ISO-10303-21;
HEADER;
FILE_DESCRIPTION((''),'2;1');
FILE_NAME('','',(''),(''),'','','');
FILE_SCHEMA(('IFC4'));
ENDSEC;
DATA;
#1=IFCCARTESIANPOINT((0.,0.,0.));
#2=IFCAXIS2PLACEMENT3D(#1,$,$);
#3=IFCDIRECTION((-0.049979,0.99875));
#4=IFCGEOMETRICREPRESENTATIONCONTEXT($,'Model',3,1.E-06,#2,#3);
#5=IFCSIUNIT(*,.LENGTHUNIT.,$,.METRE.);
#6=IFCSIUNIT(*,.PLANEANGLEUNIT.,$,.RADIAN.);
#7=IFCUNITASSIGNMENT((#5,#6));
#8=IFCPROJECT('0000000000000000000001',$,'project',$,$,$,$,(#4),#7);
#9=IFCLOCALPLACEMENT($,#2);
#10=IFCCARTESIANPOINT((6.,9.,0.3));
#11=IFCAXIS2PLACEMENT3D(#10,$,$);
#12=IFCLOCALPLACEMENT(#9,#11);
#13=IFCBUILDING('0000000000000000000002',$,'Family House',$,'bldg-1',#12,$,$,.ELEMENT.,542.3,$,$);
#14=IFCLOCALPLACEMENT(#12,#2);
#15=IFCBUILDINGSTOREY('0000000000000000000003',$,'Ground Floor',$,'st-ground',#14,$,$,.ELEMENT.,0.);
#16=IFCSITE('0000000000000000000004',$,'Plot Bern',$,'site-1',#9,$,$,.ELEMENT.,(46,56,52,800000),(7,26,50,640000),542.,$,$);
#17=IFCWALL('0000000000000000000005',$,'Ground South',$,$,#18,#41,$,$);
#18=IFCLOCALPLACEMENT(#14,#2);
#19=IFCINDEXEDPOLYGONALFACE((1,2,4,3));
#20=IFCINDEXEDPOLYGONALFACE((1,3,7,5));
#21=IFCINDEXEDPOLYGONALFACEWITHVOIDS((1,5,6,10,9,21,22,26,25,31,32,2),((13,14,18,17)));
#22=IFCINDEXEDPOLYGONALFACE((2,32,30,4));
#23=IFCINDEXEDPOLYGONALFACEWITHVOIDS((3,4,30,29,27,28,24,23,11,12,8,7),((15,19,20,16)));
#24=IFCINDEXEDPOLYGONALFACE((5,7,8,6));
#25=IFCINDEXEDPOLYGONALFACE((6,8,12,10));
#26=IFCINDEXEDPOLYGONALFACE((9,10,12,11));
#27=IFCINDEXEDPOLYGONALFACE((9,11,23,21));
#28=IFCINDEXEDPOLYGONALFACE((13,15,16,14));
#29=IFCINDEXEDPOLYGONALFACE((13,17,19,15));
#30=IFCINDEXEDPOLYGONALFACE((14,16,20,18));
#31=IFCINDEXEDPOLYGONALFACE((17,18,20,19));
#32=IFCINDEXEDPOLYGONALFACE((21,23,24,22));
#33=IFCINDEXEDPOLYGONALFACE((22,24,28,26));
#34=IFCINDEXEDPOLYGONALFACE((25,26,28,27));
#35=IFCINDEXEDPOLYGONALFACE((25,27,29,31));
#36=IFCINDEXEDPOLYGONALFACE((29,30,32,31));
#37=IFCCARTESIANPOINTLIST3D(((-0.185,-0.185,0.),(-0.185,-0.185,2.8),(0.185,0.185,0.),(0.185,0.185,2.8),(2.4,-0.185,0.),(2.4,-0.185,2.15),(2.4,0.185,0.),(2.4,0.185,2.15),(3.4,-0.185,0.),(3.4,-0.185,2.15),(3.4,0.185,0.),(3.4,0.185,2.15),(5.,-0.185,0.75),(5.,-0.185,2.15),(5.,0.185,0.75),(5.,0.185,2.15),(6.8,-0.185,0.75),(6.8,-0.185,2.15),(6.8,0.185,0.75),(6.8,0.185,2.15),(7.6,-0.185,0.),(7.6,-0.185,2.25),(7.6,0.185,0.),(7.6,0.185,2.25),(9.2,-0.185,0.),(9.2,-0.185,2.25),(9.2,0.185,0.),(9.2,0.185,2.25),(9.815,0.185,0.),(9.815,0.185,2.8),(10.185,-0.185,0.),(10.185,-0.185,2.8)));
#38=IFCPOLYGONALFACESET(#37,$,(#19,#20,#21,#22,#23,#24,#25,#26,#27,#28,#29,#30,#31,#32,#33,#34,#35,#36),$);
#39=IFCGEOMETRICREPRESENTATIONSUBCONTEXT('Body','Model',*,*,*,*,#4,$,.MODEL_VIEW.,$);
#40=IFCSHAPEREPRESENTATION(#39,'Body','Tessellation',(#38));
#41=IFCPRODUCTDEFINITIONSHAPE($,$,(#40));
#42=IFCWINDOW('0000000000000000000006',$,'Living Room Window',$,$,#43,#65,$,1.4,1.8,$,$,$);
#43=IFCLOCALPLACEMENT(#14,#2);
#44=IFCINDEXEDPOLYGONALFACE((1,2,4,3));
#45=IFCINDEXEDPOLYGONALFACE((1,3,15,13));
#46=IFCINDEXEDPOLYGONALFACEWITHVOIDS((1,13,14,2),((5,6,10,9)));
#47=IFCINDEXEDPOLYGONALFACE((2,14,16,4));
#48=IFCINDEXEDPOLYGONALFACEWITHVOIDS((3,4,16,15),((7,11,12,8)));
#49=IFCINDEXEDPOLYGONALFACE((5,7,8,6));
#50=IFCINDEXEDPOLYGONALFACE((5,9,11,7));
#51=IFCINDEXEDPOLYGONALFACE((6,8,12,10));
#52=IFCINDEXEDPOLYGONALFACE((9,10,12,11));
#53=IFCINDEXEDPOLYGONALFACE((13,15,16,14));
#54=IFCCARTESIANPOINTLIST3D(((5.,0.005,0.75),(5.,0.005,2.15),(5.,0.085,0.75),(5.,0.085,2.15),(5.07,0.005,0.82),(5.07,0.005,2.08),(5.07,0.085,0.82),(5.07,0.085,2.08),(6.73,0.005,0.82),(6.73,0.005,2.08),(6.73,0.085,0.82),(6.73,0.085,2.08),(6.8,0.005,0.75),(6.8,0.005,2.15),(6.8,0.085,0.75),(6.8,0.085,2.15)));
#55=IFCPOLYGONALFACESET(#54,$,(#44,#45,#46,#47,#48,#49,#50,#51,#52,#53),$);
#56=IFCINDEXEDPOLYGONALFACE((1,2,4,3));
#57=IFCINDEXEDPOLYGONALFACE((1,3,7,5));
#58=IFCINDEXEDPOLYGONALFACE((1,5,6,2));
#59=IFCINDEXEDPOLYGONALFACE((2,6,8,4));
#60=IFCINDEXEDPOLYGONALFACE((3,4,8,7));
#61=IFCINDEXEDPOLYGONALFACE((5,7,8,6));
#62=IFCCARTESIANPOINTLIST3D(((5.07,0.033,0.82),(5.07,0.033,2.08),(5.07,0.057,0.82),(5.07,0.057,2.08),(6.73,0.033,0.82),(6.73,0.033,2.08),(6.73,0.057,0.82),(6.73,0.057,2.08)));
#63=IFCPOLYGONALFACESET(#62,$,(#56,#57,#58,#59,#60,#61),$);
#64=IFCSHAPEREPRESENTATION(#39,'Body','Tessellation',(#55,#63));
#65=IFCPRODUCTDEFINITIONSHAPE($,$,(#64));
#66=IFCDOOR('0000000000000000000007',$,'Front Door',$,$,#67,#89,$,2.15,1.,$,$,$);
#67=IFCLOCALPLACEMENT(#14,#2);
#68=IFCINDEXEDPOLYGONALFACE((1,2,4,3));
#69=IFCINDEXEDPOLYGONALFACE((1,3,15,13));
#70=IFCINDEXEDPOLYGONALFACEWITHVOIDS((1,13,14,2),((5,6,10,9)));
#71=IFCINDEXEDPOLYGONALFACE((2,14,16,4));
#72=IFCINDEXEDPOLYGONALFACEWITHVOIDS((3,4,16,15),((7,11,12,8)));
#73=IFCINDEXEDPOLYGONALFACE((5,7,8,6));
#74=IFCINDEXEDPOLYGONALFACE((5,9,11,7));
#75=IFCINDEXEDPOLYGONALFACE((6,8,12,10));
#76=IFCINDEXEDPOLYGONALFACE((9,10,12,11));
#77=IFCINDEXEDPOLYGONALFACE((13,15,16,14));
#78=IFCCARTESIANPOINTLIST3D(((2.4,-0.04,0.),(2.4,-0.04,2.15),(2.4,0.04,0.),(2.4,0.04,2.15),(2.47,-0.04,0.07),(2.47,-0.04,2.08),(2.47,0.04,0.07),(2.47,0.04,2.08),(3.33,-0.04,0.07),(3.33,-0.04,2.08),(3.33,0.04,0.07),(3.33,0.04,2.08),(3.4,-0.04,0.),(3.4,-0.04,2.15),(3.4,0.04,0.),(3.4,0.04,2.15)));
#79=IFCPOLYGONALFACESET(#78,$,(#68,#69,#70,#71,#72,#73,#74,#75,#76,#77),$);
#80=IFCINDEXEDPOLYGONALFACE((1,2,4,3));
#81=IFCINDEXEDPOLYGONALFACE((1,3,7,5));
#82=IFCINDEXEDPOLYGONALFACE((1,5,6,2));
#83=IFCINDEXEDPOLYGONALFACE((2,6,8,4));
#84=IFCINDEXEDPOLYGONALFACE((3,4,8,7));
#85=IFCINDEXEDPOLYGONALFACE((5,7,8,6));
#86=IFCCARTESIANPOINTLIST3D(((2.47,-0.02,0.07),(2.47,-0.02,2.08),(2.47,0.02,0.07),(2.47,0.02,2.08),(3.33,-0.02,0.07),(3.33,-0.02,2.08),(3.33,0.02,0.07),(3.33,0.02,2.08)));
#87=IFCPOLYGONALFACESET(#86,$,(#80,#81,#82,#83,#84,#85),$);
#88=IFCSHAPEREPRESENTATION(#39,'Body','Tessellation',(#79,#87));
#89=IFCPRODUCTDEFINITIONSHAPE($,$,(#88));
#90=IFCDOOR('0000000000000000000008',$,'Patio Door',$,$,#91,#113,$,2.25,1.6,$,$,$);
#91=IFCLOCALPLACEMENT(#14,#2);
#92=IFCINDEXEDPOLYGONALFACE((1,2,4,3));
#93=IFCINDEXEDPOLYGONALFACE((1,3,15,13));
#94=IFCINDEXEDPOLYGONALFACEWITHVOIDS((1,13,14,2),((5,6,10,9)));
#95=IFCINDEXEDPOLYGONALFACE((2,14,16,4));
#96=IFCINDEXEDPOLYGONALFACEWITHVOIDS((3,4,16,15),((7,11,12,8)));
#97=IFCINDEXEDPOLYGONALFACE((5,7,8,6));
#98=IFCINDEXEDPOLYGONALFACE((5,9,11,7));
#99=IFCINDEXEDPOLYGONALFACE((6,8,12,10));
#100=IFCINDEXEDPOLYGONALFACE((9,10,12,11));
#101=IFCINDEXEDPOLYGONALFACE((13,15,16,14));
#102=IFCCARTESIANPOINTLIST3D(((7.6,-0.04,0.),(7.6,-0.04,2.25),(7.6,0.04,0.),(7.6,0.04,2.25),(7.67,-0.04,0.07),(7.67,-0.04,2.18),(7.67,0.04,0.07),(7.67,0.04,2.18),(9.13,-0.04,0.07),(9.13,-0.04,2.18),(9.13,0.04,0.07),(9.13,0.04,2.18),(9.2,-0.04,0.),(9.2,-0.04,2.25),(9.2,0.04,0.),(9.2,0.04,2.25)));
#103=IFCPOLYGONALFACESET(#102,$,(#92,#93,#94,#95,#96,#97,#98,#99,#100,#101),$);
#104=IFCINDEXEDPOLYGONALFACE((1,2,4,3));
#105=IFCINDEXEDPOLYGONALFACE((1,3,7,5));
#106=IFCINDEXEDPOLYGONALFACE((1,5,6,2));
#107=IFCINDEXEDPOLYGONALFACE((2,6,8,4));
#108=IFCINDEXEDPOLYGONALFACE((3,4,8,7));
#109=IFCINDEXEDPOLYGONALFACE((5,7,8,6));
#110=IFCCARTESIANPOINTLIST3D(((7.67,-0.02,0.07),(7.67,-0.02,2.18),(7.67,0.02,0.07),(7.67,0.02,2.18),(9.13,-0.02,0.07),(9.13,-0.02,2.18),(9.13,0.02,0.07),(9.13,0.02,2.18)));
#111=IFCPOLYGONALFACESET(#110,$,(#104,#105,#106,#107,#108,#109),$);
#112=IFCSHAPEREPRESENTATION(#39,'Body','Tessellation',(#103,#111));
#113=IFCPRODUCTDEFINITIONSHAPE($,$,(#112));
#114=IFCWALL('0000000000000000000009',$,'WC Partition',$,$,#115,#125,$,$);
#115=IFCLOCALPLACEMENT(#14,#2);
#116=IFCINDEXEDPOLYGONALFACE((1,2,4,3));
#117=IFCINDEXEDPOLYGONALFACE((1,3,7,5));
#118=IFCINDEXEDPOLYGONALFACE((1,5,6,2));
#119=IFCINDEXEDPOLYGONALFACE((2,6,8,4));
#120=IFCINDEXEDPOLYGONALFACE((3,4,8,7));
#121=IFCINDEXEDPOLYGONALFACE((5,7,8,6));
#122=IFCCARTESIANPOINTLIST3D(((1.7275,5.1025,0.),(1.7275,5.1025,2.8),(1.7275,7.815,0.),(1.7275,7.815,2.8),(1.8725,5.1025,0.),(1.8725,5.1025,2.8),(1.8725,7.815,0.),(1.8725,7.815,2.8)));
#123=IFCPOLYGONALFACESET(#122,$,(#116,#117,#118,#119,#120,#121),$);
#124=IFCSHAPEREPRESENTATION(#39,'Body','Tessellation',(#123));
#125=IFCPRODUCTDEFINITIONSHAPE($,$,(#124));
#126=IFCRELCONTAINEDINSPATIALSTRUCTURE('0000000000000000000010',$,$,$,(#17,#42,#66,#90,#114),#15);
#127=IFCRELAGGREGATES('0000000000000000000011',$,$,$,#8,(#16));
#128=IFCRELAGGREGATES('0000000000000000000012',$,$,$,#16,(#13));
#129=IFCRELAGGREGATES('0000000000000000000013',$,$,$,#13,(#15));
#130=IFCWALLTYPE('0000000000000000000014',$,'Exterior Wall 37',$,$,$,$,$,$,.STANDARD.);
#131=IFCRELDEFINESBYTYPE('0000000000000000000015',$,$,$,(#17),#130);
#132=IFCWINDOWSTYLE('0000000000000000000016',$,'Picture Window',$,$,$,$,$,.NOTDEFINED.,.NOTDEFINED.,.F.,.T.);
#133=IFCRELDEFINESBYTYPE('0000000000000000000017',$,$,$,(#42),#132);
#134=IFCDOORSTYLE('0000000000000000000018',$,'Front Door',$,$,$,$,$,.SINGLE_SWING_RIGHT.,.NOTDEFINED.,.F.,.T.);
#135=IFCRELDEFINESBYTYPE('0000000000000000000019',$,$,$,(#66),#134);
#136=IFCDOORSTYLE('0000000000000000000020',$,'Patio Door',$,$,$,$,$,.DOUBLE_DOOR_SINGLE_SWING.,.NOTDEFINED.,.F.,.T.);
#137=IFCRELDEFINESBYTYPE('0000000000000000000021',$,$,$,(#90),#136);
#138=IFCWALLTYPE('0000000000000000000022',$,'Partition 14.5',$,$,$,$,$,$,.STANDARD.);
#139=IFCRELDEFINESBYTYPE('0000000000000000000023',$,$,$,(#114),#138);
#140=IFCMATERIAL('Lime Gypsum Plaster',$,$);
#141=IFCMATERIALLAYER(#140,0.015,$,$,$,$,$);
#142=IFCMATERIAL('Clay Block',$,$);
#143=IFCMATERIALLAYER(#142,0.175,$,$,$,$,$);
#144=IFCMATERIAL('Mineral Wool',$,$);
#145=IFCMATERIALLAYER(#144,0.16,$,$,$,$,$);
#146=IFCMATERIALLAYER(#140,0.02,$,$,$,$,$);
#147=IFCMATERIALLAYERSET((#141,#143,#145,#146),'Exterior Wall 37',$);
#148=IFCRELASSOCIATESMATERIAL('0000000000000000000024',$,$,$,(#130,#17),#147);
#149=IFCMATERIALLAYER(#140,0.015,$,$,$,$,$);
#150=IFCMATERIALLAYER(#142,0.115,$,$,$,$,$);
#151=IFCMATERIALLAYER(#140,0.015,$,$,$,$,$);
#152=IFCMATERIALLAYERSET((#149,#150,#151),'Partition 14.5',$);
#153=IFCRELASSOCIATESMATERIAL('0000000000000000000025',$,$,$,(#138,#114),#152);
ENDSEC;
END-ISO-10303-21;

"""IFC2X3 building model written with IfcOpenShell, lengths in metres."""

from ifc_helpers import new_model, si_unit, direction, frame, frame_2d, origin, origin_2d, place, context, subcontext, project, spatial, polyline, rectangle, outline, extrude, material, layer, layer_set, layer_usage, type_object, element, fill, save


model = new_model("IFC2X3")

# Units and contexts
model_context = context("Model", 3, precision=1e-06, world=origin(), true_north=direction((-0.049979, 0.99875)))
body_context = subcontext(model_context, "Body", "Model", "MODEL_VIEW")
ifc_project = project(units=[si_unit("LENGTHUNIT", "METRE"), si_unit("PLANEANGLEUNIT", "RADIAN")], contexts=[model_context])

# Site, building, storey
site_placement = place(None, origin())
site = spatial("IfcSite", under=ifc_project, at=site_placement, Name="Plot Bern", ObjectType="site-1", CompositionType="ELEMENT", RefLatitude=(46, 56, 52, 800000), RefLongitude=(7, 26, 50, 640000), RefElevation=542.0)
building_placement = place(site_placement, frame((6.0, 9.0, 0.3)))
building = spatial("IfcBuilding", under=site, at=building_placement, Name="Family House", ObjectType="bldg-1", CompositionType="ELEMENT", ElevationOfRefHeight=542.3)
storey_placement = place(building_placement, origin())
storey = spatial("IfcBuildingStorey", under=building, at=storey_placement, Name="Ground Floor", ObjectType="st-ground", CompositionType="ELEMENT", Elevation=0.0)

# Shared definitions
ifc_material_1 = material(Name="Mineral Wool")

# Shared definitions
ifc_material_2 = material(Name="Lime Gypsum Plaster")
ifc_layer_1 = layer(ifc_material_2, 0.015)
ifc_material_3 = material(Name="Clay Block")
ifc_layer_2 = layer(ifc_material_3, 0.175)
ifc_layer_3 = layer(ifc_material_1, 0.16)
ifc_layer_4 = layer(ifc_material_2, 0.02)
ifc_layer_set_1 = layer_set([ifc_layer_1, ifc_layer_2, ifc_layer_3, ifc_layer_4], Name="Exterior Wall 37")
wall_type_1 = type_object("IfcWallType", Name="Exterior Wall 37", PredefinedType="STANDARD", material=ifc_layer_set_1)

# Wall, openings, window, doors
ifc_layer_usage_1 = layer_usage(ifc_layer_set_1, "AXIS2", "NEGATIVE", 0.185)
wall_1_placement = place(storey_placement, origin())
wall_1 = element("IfcWall", 1, at=wall_1_placement, inside=storey, type_object=wall_type_1, material=ifc_layer_usage_1, Name="Ground South", context=body_context, shape_type="SweptSolid", body=[
    extrude(outline(polyline([(-0.185, -0.185), (10.185, -0.185), (9.815, 0.185), (0.185, 0.185), (-0.185, -0.185)])), origin(), (0.0, 0.0, 1.0), 2.8),
])
opening_1_placement = place(wall_1_placement, frame((2.9, 0.0, 0.0), z_axis=(0.0, 0.0, 1.0), x_axis=(1.0, 0.0, 0.0)))
opening_1 = element("IfcOpeningElement", 2, at=opening_1_placement, cuts=wall_1, context=body_context, shape_type="SweptSolid", body=[
    extrude(rectangle(XDim=1.0, YDim=0.37, at=origin_2d()), origin(), (0.0, 0.0, 1.0), 2.15),
])
opening_2_placement = place(wall_1_placement, frame((5.9, 0.0, 0.75), z_axis=(0.0, 0.0, 1.0), x_axis=(1.0, 0.0, 0.0)))
opening_2 = element("IfcOpeningElement", 3, at=opening_2_placement, cuts=wall_1, context=body_context, shape_type="SweptSolid", body=[
    extrude(rectangle(XDim=1.8, YDim=0.37, at=origin_2d()), origin(), (0.0, 0.0, 1.0), 1.4),
])
opening_3_placement = place(wall_1_placement, frame((8.4, 0.0, 0.0), z_axis=(0.0, 0.0, 1.0), x_axis=(1.0, 0.0, 0.0)))
opening_3 = element("IfcOpeningElement", 4, at=opening_3_placement, cuts=wall_1, context=body_context, shape_type="SweptSolid", body=[
    extrude(rectangle(XDim=1.6, YDim=0.37, at=origin_2d()), origin(), (0.0, 0.0, 1.0), 2.25),
])
window_style_1 = type_object("IfcWindowStyle", Name="Picture Window", ConstructionType="NOTDEFINED", OperationType="NOTDEFINED", ParameterTakesPrecedence=False, Sizeable=True)
window_1_placement = place(opening_2_placement, frame((0.0, 0.045, 0.0), z_axis=(0.0, -1.0, 0.0), x_axis=(1.0, 0.0, 0.0)))
window_1 = element("IfcWindow", 5, at=window_1_placement, inside=storey, type_object=window_style_1, Name="Living Room Window", OverallHeight=1.4, OverallWidth=1.8, context=body_context, shape_type="SweptSolid", body=[
    extrude(outline(polyline([(-0.9, 0.0), (0.9, 0.0), (0.9, 1.4), (-0.9, 1.4), (-0.9, 0.0)]), holes=[polyline([(-0.83, 0.07), (0.83, 0.07), (0.83, 1.33), (-0.83, 1.33), (-0.83, 0.07)])]), frame((0.0, 0.0, -0.04)), (0.0, 0.0, 1.0), 0.08),
    extrude(rectangle(XDim=1.66, YDim=1.26, at=frame_2d((0.0, 0.7))), frame((0.0, 0.0, -0.012)), (0.0, 0.0, 1.0), 0.024),
])
fill(opening_2, window_1)
door_style_1 = type_object("IfcDoorStyle", Name="Front Door", ConstructionType="NOTDEFINED", OperationType="SINGLE_SWING_RIGHT", ParameterTakesPrecedence=False, Sizeable=True)
door_1_placement = place(opening_1_placement, frame((0.0, 0.0, 0.0), z_axis=(0.0, -1.0, 0.0), x_axis=(1.0, 0.0, 0.0)))
door_1 = element("IfcDoor", 6, at=door_1_placement, inside=storey, type_object=door_style_1, Name="Front Door", OverallHeight=2.15, OverallWidth=1.0, context=body_context, shape_type="SweptSolid", body=[
    extrude(outline(polyline([(-0.5, 0.0), (0.5, 0.0), (0.5, 2.15), (-0.5, 2.15), (-0.5, 0.0)]), holes=[polyline([(-0.43, 0.07), (0.43, 0.07), (0.43, 2.08), (-0.43, 2.08), (-0.43, 0.07)])]), frame((0.0, 0.0, -0.04)), (0.0, 0.0, 1.0), 0.08),
    extrude(rectangle(XDim=0.86, YDim=2.01, at=frame_2d((0.0, 1.075))), frame((0.0, 0.0, -0.02)), (0.0, 0.0, 1.0), 0.04),
])
fill(opening_1, door_1)
door_style_2 = type_object("IfcDoorStyle", Name="Patio Door", ConstructionType="NOTDEFINED", OperationType="DOUBLE_DOOR_SINGLE_SWING", ParameterTakesPrecedence=False, Sizeable=True)
door_2_placement = place(opening_3_placement, frame((0.0, 0.0, 0.0), z_axis=(0.0, -1.0, 0.0), x_axis=(1.0, 0.0, 0.0)))
door_2 = element("IfcDoor", 7, at=door_2_placement, inside=storey, type_object=door_style_2, Name="Patio Door", OverallHeight=2.25, OverallWidth=1.6, context=body_context, shape_type="SweptSolid", body=[
    extrude(outline(polyline([(-0.8, 0.0), (0.8, 0.0), (0.8, 2.25), (-0.8, 2.25), (-0.8, 0.0)]), holes=[polyline([(-0.73, 0.07), (0.73, 0.07), (0.73, 2.18), (-0.73, 2.18), (-0.73, 0.07)])]), frame((0.0, 0.0, -0.04)), (0.0, 0.0, 1.0), 0.08),
    extrude(rectangle(XDim=1.46, YDim=2.11, at=frame_2d((0.0, 1.125))), frame((0.0, 0.0, -0.02)), (0.0, 0.0, 1.0), 0.04),
])
fill(opening_3, door_2)

# Wall
ifc_layer_5 = layer(ifc_material_2, 0.015)
ifc_layer_6 = layer(ifc_material_3, 0.115)
ifc_layer_7 = layer(ifc_material_2, 0.015)
ifc_layer_set_2 = layer_set([ifc_layer_5, ifc_layer_6, ifc_layer_7], Name="Partition 14.5")
ifc_layer_usage_2 = layer_usage(ifc_layer_set_2, "AXIS2", "NEGATIVE", 0.0725)
wall_type_2 = type_object("IfcWallType", Name="Partition 14.5", PredefinedType="STANDARD", material=ifc_layer_set_2)
wall_2_placement = place(storey_placement, origin())
element("IfcWall", 8, at=wall_2_placement, inside=storey, type_object=wall_type_2, material=ifc_layer_usage_2, Name="WC Partition", context=body_context, shape_type="SweptSolid", body=[
    extrude(outline(polyline([(1.8725, 5.1025), (1.8725, 7.815), (1.7275, 7.815), (1.7275, 5.1025), (1.8725, 5.1025)])), origin(), (0.0, 0.0, 1.0), 2.8),
])

save(model, "model.ifc")
